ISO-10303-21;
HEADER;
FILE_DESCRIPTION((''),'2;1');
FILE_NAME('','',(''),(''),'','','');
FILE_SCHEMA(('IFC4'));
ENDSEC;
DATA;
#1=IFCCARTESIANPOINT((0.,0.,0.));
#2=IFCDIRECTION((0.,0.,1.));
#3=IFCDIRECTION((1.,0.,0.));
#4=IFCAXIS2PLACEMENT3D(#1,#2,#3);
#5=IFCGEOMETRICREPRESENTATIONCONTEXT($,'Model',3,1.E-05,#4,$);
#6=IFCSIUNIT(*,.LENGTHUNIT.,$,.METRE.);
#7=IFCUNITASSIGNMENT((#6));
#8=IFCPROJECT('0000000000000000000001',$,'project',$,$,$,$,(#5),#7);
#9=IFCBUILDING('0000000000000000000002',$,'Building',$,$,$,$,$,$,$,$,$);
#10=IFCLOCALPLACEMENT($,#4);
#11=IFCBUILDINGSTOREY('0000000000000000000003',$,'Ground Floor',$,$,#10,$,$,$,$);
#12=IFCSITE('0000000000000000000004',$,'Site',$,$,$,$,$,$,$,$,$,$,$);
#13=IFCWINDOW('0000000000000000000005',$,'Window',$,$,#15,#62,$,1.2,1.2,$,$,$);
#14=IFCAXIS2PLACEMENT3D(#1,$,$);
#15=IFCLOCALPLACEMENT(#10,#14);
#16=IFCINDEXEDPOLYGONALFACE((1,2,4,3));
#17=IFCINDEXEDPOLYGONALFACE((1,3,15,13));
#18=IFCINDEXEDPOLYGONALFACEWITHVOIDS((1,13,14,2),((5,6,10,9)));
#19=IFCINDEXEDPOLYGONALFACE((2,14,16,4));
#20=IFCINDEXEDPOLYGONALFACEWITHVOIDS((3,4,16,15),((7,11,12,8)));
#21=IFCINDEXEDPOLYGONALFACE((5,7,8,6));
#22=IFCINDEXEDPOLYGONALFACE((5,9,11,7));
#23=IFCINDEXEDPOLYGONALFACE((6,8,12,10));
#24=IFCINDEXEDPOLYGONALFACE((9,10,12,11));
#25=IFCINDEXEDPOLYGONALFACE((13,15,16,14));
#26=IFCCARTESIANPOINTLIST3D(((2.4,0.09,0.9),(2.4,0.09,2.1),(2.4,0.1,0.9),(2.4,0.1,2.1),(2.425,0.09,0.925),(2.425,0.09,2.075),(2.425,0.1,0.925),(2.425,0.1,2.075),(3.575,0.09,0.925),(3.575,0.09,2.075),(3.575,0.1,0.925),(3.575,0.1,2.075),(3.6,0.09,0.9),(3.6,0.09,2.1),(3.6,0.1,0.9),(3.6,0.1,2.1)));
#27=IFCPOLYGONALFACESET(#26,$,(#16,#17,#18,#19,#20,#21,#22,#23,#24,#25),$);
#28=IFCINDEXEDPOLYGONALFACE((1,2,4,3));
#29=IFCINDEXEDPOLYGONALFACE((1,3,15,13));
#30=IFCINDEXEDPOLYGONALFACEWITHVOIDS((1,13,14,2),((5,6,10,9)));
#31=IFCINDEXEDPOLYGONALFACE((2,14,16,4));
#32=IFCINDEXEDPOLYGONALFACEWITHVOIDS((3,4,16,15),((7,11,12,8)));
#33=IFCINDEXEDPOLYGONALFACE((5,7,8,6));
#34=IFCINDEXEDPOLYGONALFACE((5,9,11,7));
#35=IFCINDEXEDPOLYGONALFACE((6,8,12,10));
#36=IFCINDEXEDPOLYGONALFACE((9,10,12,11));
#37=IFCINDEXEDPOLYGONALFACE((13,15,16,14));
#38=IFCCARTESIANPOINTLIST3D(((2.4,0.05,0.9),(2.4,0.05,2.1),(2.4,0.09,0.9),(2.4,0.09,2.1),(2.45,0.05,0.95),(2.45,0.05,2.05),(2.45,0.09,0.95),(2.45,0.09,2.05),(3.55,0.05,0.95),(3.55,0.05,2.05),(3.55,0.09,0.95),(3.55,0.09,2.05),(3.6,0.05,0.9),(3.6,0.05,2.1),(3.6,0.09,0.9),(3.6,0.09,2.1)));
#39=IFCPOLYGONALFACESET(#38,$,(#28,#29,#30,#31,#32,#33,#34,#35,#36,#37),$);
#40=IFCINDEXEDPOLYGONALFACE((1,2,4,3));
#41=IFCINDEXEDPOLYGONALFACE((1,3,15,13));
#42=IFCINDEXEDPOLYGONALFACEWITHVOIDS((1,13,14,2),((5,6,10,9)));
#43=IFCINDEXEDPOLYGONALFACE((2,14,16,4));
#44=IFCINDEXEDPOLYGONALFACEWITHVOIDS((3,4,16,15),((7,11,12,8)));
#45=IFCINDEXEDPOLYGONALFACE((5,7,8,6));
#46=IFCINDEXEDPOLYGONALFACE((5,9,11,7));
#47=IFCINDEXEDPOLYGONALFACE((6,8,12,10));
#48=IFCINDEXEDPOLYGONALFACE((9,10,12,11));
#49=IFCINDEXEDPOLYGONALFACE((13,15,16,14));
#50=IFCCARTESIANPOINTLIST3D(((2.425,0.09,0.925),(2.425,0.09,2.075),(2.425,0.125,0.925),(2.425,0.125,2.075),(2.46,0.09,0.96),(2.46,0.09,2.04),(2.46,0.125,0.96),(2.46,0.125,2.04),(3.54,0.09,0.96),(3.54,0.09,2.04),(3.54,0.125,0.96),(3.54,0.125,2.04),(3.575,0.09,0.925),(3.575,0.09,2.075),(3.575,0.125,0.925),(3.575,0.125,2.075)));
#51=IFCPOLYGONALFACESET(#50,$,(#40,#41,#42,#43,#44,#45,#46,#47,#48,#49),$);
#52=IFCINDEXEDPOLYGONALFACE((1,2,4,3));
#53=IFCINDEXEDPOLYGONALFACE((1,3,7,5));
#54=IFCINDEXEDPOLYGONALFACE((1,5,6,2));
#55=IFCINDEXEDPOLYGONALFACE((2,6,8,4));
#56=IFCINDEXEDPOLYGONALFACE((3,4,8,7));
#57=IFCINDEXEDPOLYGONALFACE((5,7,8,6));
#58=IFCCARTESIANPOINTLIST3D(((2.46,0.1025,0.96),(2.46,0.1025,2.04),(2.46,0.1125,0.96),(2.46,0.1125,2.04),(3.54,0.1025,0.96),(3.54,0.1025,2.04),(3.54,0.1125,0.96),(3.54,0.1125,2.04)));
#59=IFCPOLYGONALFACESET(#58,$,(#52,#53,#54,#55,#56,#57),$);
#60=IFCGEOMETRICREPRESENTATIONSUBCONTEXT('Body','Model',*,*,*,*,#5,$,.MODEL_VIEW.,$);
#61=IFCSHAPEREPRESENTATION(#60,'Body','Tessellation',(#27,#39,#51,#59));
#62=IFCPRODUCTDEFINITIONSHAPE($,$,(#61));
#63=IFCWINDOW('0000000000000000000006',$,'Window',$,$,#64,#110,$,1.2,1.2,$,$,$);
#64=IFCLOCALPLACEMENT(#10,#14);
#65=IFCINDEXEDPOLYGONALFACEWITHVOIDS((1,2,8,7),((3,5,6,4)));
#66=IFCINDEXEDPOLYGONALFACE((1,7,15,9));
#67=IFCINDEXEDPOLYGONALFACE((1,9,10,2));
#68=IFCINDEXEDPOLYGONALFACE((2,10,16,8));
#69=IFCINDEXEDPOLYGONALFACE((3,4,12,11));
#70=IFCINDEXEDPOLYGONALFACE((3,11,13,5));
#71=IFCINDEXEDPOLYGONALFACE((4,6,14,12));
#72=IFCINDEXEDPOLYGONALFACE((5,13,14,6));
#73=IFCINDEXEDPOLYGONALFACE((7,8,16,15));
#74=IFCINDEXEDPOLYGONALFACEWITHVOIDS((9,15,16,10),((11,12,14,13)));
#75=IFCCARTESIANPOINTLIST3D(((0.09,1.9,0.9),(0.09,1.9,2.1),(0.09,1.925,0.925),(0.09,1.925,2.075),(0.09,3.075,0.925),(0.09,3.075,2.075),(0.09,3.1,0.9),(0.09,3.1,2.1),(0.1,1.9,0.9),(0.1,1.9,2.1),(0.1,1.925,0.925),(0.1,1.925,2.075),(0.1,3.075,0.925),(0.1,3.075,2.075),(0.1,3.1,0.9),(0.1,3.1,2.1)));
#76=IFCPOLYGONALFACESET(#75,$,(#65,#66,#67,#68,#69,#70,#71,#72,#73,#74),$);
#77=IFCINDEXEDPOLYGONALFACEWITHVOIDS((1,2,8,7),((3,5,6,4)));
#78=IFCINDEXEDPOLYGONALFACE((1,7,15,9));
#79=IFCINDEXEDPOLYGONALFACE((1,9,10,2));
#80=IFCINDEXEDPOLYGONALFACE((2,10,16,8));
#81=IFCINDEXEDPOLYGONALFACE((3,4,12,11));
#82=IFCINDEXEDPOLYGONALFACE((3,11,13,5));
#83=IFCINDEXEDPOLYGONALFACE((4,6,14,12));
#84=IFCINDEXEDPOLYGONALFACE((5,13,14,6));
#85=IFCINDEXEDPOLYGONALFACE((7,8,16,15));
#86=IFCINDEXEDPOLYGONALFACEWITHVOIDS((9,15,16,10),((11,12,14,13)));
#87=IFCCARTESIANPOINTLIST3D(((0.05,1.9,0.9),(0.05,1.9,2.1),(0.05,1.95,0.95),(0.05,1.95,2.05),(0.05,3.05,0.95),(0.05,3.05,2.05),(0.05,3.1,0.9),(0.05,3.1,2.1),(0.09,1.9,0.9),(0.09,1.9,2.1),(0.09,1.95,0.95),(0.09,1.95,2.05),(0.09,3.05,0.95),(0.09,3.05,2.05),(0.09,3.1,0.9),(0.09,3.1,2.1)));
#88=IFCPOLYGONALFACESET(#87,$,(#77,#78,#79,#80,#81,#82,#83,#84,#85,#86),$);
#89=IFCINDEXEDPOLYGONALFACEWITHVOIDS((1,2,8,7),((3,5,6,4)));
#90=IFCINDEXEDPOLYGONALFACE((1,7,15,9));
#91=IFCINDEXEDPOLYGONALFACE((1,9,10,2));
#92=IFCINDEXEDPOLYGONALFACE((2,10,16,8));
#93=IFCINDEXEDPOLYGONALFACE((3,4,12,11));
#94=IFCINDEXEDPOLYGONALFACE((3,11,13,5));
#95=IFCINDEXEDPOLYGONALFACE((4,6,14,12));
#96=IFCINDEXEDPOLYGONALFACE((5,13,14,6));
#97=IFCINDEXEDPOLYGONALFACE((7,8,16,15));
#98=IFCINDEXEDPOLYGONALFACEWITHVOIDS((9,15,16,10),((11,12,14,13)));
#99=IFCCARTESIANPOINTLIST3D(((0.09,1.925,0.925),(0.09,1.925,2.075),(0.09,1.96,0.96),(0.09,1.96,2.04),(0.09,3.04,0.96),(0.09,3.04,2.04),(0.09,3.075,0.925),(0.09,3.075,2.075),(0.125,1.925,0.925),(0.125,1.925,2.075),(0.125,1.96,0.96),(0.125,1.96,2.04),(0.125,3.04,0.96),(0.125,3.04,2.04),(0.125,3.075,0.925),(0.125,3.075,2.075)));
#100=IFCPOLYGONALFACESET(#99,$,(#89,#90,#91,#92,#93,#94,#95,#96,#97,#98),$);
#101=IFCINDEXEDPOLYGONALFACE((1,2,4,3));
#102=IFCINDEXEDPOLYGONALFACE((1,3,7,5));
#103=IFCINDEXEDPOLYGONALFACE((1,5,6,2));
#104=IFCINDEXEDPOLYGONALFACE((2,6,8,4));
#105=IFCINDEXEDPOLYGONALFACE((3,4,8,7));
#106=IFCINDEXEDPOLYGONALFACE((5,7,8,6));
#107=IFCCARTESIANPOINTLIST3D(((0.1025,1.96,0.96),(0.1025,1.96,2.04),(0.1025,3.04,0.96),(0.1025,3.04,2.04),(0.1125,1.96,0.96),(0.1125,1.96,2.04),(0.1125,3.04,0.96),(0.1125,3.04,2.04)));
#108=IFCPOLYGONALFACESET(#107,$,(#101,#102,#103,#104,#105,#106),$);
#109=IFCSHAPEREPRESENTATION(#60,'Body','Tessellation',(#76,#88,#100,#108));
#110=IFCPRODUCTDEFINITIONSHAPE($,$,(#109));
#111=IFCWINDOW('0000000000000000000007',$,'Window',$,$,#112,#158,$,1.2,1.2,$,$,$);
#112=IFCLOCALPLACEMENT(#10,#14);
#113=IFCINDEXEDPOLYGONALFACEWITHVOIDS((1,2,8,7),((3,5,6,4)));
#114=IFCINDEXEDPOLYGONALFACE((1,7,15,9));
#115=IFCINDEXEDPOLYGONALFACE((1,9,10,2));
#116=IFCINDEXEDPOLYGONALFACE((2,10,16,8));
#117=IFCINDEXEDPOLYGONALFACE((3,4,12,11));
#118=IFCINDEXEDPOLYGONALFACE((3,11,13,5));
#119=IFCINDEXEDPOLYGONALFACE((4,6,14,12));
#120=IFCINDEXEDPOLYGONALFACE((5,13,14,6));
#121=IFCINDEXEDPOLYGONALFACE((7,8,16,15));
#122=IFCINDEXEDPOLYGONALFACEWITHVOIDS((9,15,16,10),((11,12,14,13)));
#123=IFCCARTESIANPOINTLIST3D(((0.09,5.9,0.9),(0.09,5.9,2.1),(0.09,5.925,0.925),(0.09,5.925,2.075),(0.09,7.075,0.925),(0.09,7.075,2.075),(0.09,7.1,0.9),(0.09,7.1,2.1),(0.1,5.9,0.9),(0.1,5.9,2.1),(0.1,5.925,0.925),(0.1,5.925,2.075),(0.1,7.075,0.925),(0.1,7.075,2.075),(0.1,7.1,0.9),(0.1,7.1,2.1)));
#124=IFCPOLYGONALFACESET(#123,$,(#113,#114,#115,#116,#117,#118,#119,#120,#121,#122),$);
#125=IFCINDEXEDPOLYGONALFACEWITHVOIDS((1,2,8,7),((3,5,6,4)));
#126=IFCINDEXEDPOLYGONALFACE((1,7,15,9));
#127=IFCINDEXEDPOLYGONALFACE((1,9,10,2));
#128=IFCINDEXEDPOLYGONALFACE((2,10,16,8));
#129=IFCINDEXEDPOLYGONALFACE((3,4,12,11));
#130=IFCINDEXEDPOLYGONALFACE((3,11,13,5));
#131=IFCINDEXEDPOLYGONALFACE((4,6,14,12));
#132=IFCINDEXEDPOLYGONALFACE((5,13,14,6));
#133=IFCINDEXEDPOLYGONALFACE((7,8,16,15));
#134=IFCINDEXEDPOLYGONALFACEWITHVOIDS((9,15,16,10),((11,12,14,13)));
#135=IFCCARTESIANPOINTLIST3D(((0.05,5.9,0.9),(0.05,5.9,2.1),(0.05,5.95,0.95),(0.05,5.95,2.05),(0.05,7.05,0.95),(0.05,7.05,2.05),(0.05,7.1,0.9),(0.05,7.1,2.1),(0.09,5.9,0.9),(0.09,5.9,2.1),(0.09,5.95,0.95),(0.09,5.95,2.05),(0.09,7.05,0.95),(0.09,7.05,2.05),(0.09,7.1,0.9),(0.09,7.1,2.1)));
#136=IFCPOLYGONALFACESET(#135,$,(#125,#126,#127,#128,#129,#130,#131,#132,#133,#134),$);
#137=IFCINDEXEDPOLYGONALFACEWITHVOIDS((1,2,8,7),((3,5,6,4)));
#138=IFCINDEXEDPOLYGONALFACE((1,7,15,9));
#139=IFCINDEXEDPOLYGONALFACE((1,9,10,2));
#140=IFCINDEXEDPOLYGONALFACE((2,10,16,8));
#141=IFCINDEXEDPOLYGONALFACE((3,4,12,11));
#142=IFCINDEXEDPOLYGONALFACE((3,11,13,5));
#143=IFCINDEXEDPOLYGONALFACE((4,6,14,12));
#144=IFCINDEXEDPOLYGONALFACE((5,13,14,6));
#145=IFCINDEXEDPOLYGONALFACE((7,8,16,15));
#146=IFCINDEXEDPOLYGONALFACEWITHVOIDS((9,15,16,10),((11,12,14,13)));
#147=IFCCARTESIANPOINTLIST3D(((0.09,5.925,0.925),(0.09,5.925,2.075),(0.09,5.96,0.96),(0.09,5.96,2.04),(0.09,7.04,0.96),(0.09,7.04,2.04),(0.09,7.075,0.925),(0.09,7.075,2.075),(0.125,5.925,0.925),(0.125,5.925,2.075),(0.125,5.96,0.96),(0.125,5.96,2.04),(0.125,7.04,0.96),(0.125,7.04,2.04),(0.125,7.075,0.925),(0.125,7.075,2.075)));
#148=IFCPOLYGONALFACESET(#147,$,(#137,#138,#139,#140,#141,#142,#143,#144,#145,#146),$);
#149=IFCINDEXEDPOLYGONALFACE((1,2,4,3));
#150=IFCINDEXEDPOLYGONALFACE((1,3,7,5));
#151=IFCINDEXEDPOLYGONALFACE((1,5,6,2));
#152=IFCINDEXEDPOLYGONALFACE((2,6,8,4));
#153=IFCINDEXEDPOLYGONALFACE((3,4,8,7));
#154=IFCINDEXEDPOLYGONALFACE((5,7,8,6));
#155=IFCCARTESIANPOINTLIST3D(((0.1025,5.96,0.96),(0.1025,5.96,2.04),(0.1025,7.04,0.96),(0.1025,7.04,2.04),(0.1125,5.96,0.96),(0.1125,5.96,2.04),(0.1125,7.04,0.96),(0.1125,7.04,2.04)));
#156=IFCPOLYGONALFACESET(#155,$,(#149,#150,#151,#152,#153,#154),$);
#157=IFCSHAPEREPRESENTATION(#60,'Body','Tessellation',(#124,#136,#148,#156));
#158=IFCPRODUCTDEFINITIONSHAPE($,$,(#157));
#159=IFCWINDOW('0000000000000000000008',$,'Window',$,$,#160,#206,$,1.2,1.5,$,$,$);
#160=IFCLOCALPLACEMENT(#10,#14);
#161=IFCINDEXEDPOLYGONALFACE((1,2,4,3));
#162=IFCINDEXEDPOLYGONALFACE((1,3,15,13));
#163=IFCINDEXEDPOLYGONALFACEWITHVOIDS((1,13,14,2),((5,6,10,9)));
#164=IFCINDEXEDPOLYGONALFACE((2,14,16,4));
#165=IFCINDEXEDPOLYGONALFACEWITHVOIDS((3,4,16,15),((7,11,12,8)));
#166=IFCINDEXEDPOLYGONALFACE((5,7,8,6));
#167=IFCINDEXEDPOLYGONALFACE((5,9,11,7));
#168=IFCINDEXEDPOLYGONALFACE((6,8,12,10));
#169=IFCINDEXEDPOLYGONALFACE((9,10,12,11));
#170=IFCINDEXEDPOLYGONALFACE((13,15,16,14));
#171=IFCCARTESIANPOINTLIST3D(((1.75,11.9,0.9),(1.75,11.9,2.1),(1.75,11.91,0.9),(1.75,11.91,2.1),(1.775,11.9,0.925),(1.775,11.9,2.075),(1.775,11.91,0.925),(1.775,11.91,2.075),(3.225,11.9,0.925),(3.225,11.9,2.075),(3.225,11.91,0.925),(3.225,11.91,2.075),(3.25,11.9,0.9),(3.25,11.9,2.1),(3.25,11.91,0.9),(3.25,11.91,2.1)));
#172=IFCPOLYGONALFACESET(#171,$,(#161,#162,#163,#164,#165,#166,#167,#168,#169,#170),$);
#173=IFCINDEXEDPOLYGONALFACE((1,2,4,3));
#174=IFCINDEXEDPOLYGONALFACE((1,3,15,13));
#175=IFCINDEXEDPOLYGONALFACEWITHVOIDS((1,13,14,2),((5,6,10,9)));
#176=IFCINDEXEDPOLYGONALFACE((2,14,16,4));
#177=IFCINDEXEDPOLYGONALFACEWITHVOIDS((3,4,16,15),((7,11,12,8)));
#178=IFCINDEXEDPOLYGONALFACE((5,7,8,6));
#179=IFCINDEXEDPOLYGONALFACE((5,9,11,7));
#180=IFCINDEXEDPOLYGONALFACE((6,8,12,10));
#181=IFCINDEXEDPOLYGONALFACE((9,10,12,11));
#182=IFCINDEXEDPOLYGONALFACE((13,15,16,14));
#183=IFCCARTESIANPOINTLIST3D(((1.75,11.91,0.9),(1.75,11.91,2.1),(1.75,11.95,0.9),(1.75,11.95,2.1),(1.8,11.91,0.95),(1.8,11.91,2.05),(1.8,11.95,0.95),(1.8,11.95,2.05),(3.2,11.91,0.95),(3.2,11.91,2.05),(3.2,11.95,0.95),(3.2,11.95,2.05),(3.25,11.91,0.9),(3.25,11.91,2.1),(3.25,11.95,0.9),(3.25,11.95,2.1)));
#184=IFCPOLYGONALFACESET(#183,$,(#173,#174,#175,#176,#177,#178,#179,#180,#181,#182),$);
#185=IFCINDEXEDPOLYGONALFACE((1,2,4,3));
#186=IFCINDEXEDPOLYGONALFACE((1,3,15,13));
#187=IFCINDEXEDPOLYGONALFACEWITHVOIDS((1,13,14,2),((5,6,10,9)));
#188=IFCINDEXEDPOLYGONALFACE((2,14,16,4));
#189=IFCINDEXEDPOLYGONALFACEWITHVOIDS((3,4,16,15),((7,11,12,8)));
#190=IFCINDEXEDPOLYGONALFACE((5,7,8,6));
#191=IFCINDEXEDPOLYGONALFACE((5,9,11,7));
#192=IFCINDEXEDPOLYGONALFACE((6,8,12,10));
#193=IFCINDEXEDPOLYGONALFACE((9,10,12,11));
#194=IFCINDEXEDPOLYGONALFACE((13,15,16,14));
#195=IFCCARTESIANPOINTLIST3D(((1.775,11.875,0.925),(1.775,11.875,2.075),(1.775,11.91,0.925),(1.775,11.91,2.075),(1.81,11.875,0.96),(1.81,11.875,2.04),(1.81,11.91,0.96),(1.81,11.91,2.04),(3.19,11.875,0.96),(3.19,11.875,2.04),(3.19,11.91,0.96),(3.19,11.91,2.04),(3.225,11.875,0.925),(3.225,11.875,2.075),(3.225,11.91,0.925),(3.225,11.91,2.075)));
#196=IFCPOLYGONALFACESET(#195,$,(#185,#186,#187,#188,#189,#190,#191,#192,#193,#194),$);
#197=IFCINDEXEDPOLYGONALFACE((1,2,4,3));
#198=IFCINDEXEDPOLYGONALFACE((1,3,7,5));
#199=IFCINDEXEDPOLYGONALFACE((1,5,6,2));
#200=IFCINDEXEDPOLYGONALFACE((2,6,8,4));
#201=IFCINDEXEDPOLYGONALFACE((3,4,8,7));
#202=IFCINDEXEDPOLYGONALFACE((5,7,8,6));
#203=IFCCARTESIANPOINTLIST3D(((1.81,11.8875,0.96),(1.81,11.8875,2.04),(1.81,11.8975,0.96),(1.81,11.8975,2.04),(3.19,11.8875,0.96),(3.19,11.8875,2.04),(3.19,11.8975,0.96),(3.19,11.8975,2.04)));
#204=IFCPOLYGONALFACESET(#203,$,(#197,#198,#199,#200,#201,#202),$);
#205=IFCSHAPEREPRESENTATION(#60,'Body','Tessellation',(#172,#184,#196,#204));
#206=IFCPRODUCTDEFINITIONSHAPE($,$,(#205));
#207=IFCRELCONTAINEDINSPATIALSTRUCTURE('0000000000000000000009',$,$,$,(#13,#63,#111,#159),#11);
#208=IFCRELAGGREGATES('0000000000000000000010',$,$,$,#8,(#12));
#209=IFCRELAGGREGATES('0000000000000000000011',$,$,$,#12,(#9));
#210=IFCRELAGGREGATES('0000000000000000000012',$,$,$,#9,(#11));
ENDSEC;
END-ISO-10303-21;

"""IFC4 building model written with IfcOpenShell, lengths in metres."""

from ifc_helpers import new_model, si_unit, frame, origin_with_axes, place, context, subcontext, project, spatial, line, indexed_curve, outline, extrude, element, save


model = new_model("IFC4")

# Units and contexts
model_context = context("Model", 3, precision=1e-05, world=origin_with_axes())
body_context = subcontext(model_context, "Body", "Model", "MODEL_VIEW")
ifc_project = project(units=[si_unit("LENGTHUNIT", "METRE")], contexts=[model_context])

# Site, building, storey
site = spatial("IfcSite", under=ifc_project, Name="Site")
building = spatial("IfcBuilding", under=site, Name="Building")
storey_placement = place(None, origin_with_axes())
storey = spatial("IfcBuildingStorey", under=building, at=storey_placement, Name="Ground Floor")

# Windows
for number, where, z_axis, x_axis, name in (
    (1, (2.4, 0.0, 0.9), (0.0, 0.0, 1.0), (1.0, 0.0, 0.0), "Window"),
    (2, (0.0, 3.1, 0.9), (0.0, 0.0, 1.0), (0.0, -1.0, 0.0), "Window"),
    (3, (0.0, 7.1, 0.9), (0.0, 0.0, 1.0), (0.0, -1.0, 0.0), "Window"),
):
    element("IfcWindow", number, at=place(storey_placement, frame(where, z_axis=z_axis, x_axis=x_axis)), inside=storey, Name=name, OverallHeight=1.2, OverallWidth=1.2, context=body_context, shape_type="SweptSolid", body=[
        extrude(outline(indexed_curve([(0.0, 0.0), (1.2, 0.0), (1.2, 1.2), (0.0, 1.2)], segments=[line(1, 2, 3, 4, 1)]), holes=[indexed_curve([(0.025, 0.025), (1.175, 0.025), (1.175, 1.175), (0.025, 1.175)], segments=[line(1, 2, 3, 4, 1)])]), frame((0.0, 0.09, 0.0), z_axis=(0.0, -1.0, 0.0), x_axis=(1.0, 0.0, 0.0)), (0.0, 0.0, -1.0), 0.01),
        extrude(outline(indexed_curve([(0.0, 0.0), (1.2, 0.0), (1.2, 1.2), (0.0, 1.2)], segments=[line(1, 2, 3, 4, 1)]), holes=[indexed_curve([(0.05, 0.05), (1.15, 0.05), (1.15, 1.15), (0.05, 1.15)], segments=[line(1, 2, 3, 4, 1)])]), frame((0.0, 0.05, 0.0), z_axis=(0.0, -1.0, 0.0), x_axis=(1.0, 0.0, 0.0)), (0.0, 0.0, -1.0), 0.04),
        extrude(outline(indexed_curve([(0.0, 0.0), (1.15, 0.0), (1.15, 1.15), (0.0, 1.15)], segments=[line(1, 2, 3, 4, 1)]), holes=[indexed_curve([(0.035, 0.035), (1.115, 0.035), (1.115, 1.115), (0.035, 1.115)], segments=[line(1, 2, 3, 4, 1)])]), frame((0.025, 0.09, 0.025), z_axis=(0.0, -1.0, 0.0), x_axis=(1.0, 0.0, 0.0)), (0.0, 0.0, -1.0), 0.035),
        extrude(outline(indexed_curve([(0.035, 0.035), (1.115, 0.035), (1.115, 1.115), (0.035, 1.115)], segments=[line(1, 2, 3, 4, 1)])), frame((0.025, 0.1025, 0.025), z_axis=(0.0, -1.0, 0.0), x_axis=(1.0, 0.0, 0.0)), (0.0, 0.0, -1.0), 0.01),
    ])
window_1_placement = place(storey_placement, frame((3.25, 12.0, 0.9), z_axis=(0.0, 0.0, 1.0), x_axis=(-1.0, 0.0, 0.0)))
element("IfcWindow", 4, at=window_1_placement, inside=storey, Name="Window", OverallHeight=1.2, OverallWidth=1.5, context=body_context, shape_type="SweptSolid", body=[
    extrude(outline(indexed_curve([(0.0, 0.0), (1.5, 0.0), (1.5, 1.2), (0.0, 1.2)], segments=[line(1, 2, 3, 4, 1)]), holes=[indexed_curve([(0.025, 0.025), (1.475, 0.025), (1.475, 1.175), (0.025, 1.175)], segments=[line(1, 2, 3, 4, 1)])]), frame((0.0, 0.09, 0.0), z_axis=(0.0, -1.0, 0.0), x_axis=(1.0, 0.0, 0.0)), (0.0, 0.0, -1.0), 0.01),
    extrude(outline(indexed_curve([(0.0, 0.0), (1.5, 0.0), (1.5, 1.2), (0.0, 1.2)], segments=[line(1, 2, 3, 4, 1)]), holes=[indexed_curve([(0.05, 0.05), (1.45, 0.05), (1.45, 1.15), (0.05, 1.15)], segments=[line(1, 2, 3, 4, 1)])]), frame((0.0, 0.05, 0.0), z_axis=(0.0, -1.0, 0.0), x_axis=(1.0, 0.0, 0.0)), (0.0, 0.0, -1.0), 0.04),
    extrude(outline(indexed_curve([(0.0, 0.0), (1.45, 0.0), (1.45, 1.15), (0.0, 1.15)], segments=[line(1, 2, 3, 4, 1)]), holes=[indexed_curve([(0.035, 0.035), (1.415, 0.035), (1.415, 1.115), (0.035, 1.115)], segments=[line(1, 2, 3, 4, 1)])]), frame((0.025, 0.09, 0.025), z_axis=(0.0, -1.0, 0.0), x_axis=(1.0, 0.0, 0.0)), (0.0, 0.0, -1.0), 0.035),
    extrude(outline(indexed_curve([(0.035, 0.035), (1.415, 0.035), (1.415, 1.115), (0.035, 1.115)], segments=[line(1, 2, 3, 4, 1)])), frame((0.025, 0.1025, 0.025), z_axis=(0.0, -1.0, 0.0), x_axis=(1.0, 0.0, 0.0)), (0.0, 0.0, -1.0), 0.01),
])

save(model, "model.ifc")
